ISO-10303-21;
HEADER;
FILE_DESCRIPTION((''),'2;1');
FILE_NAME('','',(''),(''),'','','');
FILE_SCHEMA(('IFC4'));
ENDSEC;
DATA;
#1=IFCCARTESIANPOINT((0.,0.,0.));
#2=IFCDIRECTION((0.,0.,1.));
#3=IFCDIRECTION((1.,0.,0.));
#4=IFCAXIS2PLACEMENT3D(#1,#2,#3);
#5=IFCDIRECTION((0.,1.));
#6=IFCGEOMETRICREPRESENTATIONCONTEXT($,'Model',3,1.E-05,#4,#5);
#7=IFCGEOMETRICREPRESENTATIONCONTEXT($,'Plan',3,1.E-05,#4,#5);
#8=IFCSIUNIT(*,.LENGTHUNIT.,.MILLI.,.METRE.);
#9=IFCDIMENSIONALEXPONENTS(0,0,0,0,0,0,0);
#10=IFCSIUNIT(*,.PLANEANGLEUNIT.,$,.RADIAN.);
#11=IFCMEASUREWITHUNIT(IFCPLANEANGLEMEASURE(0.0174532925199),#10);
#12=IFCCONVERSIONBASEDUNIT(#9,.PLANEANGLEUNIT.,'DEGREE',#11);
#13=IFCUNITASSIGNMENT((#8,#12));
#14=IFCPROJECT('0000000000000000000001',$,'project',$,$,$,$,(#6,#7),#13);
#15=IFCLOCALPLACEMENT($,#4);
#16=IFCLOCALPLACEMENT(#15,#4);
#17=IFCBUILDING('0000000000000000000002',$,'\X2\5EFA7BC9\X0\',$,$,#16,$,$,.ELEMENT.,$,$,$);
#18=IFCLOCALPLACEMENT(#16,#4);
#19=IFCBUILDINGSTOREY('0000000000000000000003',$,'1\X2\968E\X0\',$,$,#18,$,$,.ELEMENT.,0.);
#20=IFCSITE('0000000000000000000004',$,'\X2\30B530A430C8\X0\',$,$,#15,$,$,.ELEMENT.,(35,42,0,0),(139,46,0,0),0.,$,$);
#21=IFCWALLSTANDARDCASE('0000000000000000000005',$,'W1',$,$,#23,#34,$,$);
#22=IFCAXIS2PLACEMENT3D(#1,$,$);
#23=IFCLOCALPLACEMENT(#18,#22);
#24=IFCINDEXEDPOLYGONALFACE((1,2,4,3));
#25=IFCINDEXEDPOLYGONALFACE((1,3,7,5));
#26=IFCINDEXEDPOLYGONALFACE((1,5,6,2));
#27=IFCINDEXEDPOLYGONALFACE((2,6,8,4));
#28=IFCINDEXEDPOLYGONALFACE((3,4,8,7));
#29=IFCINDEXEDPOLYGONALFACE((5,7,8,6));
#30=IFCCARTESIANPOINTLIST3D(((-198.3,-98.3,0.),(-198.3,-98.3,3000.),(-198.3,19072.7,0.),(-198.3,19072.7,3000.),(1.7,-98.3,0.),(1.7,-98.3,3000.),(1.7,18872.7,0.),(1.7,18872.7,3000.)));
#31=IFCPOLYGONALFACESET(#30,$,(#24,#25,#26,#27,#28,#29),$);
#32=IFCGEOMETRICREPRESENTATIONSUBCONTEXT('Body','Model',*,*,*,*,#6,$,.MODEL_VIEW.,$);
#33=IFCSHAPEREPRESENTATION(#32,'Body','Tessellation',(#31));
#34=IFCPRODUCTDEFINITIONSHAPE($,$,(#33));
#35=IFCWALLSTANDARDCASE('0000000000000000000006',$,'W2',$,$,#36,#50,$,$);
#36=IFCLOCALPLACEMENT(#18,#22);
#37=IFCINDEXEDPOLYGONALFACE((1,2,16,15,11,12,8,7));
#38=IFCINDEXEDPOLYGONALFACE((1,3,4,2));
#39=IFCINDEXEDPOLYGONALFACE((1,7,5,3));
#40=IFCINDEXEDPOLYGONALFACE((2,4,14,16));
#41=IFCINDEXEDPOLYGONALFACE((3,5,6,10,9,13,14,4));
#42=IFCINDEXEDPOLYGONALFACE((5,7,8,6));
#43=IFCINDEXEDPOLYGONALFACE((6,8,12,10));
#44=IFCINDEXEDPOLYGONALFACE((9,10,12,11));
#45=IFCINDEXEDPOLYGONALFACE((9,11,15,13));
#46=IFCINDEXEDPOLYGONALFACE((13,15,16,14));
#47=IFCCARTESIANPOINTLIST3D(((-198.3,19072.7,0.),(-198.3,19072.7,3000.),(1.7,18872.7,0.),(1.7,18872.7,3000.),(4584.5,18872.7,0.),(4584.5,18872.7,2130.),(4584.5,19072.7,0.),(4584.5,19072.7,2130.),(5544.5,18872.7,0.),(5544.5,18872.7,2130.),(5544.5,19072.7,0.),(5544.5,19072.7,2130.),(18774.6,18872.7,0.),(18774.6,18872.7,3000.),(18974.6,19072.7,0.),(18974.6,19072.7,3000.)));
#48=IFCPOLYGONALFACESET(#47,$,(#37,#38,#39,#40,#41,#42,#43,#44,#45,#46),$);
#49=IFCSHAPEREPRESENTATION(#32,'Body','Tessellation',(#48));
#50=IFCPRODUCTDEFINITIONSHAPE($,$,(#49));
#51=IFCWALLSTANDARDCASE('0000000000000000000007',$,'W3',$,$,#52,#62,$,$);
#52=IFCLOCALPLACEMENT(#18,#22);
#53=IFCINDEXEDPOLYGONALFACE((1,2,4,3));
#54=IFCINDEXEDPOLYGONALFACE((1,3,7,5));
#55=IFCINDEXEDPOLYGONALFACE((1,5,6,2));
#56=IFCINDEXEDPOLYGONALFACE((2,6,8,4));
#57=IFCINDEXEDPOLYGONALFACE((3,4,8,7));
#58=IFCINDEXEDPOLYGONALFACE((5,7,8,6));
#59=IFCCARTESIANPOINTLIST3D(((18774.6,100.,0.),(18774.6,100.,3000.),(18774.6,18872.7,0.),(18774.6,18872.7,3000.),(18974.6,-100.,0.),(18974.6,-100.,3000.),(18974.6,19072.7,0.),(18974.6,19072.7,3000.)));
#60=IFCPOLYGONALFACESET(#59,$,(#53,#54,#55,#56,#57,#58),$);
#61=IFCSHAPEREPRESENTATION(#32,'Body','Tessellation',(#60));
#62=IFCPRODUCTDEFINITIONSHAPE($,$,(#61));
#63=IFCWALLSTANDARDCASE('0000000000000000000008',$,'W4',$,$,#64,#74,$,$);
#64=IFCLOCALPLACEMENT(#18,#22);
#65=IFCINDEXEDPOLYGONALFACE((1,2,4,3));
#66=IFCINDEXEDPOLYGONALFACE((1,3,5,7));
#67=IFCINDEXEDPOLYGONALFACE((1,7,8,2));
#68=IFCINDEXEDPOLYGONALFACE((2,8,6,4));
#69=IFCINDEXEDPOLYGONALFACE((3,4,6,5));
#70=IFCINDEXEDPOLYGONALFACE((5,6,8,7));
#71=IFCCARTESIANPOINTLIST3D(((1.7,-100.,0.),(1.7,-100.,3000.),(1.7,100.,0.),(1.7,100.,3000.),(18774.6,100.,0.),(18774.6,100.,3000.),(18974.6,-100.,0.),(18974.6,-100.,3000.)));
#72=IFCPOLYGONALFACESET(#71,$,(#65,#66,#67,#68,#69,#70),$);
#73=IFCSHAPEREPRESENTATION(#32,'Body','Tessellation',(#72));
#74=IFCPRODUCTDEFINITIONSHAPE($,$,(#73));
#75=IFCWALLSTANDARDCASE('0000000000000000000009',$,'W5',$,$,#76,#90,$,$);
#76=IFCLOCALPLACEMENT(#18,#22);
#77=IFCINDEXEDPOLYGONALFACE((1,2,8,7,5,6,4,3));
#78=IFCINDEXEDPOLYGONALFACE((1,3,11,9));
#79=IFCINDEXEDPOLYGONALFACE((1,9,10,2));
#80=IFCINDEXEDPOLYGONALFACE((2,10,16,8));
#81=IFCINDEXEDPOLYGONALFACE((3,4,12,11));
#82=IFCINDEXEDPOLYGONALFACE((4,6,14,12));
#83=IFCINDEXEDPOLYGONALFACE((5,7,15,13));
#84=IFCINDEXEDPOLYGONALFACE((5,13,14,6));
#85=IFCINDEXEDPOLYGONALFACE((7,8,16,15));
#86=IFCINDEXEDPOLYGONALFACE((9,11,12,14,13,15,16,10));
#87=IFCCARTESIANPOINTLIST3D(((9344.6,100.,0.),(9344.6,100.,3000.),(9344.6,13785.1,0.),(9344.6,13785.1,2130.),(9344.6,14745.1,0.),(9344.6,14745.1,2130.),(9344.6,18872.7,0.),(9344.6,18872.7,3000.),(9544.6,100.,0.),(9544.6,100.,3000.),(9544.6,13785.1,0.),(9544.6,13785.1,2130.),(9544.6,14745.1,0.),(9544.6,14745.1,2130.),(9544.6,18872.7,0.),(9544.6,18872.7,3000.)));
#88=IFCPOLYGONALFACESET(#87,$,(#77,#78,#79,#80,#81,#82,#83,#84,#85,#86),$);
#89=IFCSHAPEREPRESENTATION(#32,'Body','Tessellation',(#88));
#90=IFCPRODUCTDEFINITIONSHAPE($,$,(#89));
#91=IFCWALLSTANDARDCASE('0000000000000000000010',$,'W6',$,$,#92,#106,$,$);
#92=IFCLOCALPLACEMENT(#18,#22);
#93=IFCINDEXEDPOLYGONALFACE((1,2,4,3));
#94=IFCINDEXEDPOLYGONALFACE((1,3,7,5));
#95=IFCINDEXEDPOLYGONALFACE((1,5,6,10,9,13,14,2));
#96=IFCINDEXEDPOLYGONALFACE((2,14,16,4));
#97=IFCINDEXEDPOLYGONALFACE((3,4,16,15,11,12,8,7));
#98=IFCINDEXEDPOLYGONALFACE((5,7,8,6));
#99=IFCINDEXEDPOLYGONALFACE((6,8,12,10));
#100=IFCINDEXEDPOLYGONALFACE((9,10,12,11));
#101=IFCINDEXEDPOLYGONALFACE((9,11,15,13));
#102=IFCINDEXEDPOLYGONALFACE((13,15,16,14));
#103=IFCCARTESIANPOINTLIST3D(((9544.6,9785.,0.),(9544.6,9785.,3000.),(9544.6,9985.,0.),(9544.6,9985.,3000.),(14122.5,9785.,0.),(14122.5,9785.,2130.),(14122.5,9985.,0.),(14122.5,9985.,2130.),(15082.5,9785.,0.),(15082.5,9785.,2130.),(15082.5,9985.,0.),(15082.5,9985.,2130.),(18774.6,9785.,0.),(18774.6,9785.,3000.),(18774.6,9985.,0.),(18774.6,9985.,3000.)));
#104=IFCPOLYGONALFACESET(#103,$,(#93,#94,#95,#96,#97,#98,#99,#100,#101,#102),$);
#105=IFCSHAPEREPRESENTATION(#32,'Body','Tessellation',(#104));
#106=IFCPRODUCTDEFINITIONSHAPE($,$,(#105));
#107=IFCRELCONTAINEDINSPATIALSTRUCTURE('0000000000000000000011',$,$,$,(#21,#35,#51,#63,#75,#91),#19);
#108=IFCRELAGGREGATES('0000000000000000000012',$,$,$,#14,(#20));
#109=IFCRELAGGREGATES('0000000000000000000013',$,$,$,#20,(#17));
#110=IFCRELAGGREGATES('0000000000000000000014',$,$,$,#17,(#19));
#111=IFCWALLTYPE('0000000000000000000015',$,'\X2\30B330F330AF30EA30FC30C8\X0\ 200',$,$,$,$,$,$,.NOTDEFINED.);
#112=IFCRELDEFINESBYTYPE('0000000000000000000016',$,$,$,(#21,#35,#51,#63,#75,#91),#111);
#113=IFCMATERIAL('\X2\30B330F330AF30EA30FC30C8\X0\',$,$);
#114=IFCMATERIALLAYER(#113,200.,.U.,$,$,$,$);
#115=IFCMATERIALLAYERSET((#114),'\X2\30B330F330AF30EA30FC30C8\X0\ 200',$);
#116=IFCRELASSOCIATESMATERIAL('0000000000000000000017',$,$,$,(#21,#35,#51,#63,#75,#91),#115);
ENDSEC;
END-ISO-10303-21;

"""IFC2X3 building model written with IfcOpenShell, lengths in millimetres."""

from ifc_helpers import new_model, entity, si_unit, converted_unit, direction, frame, origin_with_axes, origin_2d_with_axis, place, context, subcontext, project, spatial, polyline, rectangle, outline, extrude, material, layer, layer_set, layer_usage, type_object, element, save


model = new_model("IFC2X3")

# Units and contexts
model_context = context("Model", 3, precision=1e-05, world=origin_with_axes(), true_north=direction((0.0, 1.0)))
plan_context = context("Plan", 3, precision=1e-05, world=origin_with_axes(), true_north=direction((0.0, 1.0)))
body_context = subcontext(model_context, "Body", "Model", "MODEL_VIEW")
ifc_project = project(units=[si_unit("LENGTHUNIT", "METRE", prefix="MILLI"), converted_unit("PLANEANGLEUNIT", "DEGREE", entity("IfcPlaneAngleMeasure", 0.0174532925199), si_unit("PLANEANGLEUNIT", "RADIAN"), dimensions=[0, 0, 0, 0, 0, 0, 0])], contexts=[model_context, plan_context])

# Site, building, storey
site_placement = place(None, origin_with_axes())
site = spatial("IfcSite", under=ifc_project, at=site_placement, Name="サイト", CompositionType="ELEMENT", RefLatitude=(35, 42, 0, 0), RefLongitude=(139, 46, 0, 0), RefElevation=0.0)
building_placement = place(site_placement, origin_with_axes())
building = spatial("IfcBuilding", under=site, at=building_placement, Name="建築", CompositionType="ELEMENT")
storey_placement = place(building_placement, origin_with_axes())
storey = spatial("IfcBuildingStorey", under=building, at=storey_placement, Name="1階", CompositionType="ELEMENT", Elevation=0.0)

# Wall
ifc_material = material(Name="コンクリート")
ifc_layer = layer(ifc_material, 200.0, ventilated="UNKNOWN")
ifc_layer_set = layer_set([ifc_layer], Name="コンクリート 200")
ifc_layer_usage_1 = layer_usage(ifc_layer_set, "AXIS2", "POSITIVE", -100.0)
wall_type = type_object("IfcWallType", Name="コンクリート 200", PredefinedType="NOTDEFINED")
wall_1_placement = place(storey_placement, frame((-98.3, -98.3, 0.0), z_axis=(0.0, 0.0, 1.0), x_axis=(0.0, 1.0, 0.0)))
element("IfcWallStandardCase", 1, at=wall_1_placement, inside=storey, type_object=wall_type, material=ifc_layer_usage_1, Name="W1", context=body_context, shape_type="SweptSolid", body=[
    extrude(outline(polyline([(0.0, -100.0), (18971.1, -100.0), (19171.1, 100.0), (0.0, 100.0), (0.0, -100.0)])), origin_with_axes(), (0.0, 0.0, 1.0), 3000.0),
])

# Wall, opening
ifc_layer_usage_2 = layer_usage(ifc_layer_set, "AXIS2", "POSITIVE", -100.0)
wall_2_placement = place(storey_placement, frame((-98.3, 18972.7, 0.0), z_axis=(0.0, 0.0, 1.0), x_axis=(1.0, 0.0, 0.0)))
wall_2 = element("IfcWallStandardCase", 2, at=wall_2_placement, inside=storey, type_object=wall_type, material=ifc_layer_usage_2, Name="W2", context=body_context, shape_type="SweptSolid", body=[
    extrude(outline(polyline([(100.0, -100.0), (18873.0, -100.0), (19073.0, 100.0), (-100.0, 100.0), (100.0, -100.0)])), origin_with_axes(), (0.0, 0.0, 1.0), 3000.0),
])
opening_1_placement = place(wall_2_placement, frame((5162.9, 0.0, 0.0), z_axis=(0.0, 0.0, 1.0), x_axis=(1.0, 0.0, 0.0)))
element("IfcOpeningElement", 3, at=opening_1_placement, cuts=wall_2, context=body_context, shape_type="SweptSolid", body=[
    extrude(rectangle(XDim=960.0, YDim=2130.0, at=origin_2d_with_axis()), frame((0.0, 200.0, 1065.0), z_axis=(0.0, 1.0, 0.0), x_axis=(1.0, 0.0, 0.0)), (0.0, 0.0, -1.0), 400.0),
])

# Walls
ifc_layer_usage_3 = layer_usage(ifc_layer_set, "AXIS2", "POSITIVE", -100.0)
wall_3_placement = place(storey_placement, frame((18874.6, 18972.7, 0.0), z_axis=(0.0, 0.0, 1.0), x_axis=(0.0, -1.0, 0.0)))
element("IfcWallStandardCase", 4, at=wall_3_placement, inside=storey, type_object=wall_type, material=ifc_layer_usage_3, Name="W3", context=body_context, shape_type="SweptSolid", body=[
    extrude(outline(polyline([(100.0, -100.0), (18872.7, -100.0), (19072.7, 100.0), (-100.0, 100.0), (100.0, -100.0)])), origin_with_axes(), (0.0, 0.0, 1.0), 3000.0),
])
ifc_layer_usage_4 = layer_usage(ifc_layer_set, "AXIS2", "POSITIVE", -100.0)
wall_4_placement = place(storey_placement, frame((18874.6, 0.0, 0.0), z_axis=(0.0, 0.0, 1.0), x_axis=(-1.0, 0.0, 0.0)))
element("IfcWallStandardCase", 5, at=wall_4_placement, inside=storey, type_object=wall_type, material=ifc_layer_usage_4, Name="W4", context=body_context, shape_type="SweptSolid", body=[
    extrude(outline(polyline([(100.0, -100.0), (18873.0, -100.0), (18873.0, 100.0), (-100.0, 100.0), (100.0, -100.0)])), origin_with_axes(), (0.0, 0.0, 1.0), 3000.0),
])

# Walls, openings
ifc_layer_usage_5 = layer_usage(ifc_layer_set, "AXIS2", "POSITIVE", -100.0)
wall_5_placement = place(storey_placement, frame((9444.6, 18972.7, 0.0), z_axis=(0.0, 0.0, 1.0), x_axis=(0.0, -1.0, 0.0)))
wall_5 = element("IfcWallStandardCase", 6, at=wall_5_placement, inside=storey, type_object=wall_type, material=ifc_layer_usage_5, Name="W5", context=body_context, shape_type="SweptSolid", body=[
    extrude(outline(polyline([(100.0, -100.0), (18872.7, -100.0), (18872.7, 100.0), (100.0, 100.0), (100.0, -100.0)])), origin_with_axes(), (0.0, 0.0, 1.0), 3000.0),
])
opening_2_placement = place(wall_5_placement, frame((4707.6, 0.0, 0.0), z_axis=(0.0, 0.0, 1.0), x_axis=(1.0, 0.0, 0.0)))
element("IfcOpeningElement", 7, at=opening_2_placement, cuts=wall_5, context=body_context, shape_type="SweptSolid", body=[
    extrude(rectangle(XDim=960.0, YDim=2130.0, at=origin_2d_with_axis()), frame((0.0, -200.0, 1065.0), z_axis=(0.0, 1.0, 0.0), x_axis=(1.0, 0.0, 0.0)), (0.0, 0.0, 1.0), 400.0),
])
ifc_layer_usage_6 = layer_usage(ifc_layer_set, "AXIS2", "POSITIVE", -100.0)
wall_6_placement = place(storey_placement, frame((9444.6, 9885.0, 0.0), z_axis=(0.0, 0.0, 1.0), x_axis=(1.0, 0.0, 0.0)))
wall_6 = element("IfcWallStandardCase", 8, at=wall_6_placement, inside=storey, type_object=wall_type, material=ifc_layer_usage_6, Name="W6", context=body_context, shape_type="SweptSolid", body=[
    extrude(outline(polyline([(100.0, -100.0), (9330.0, -100.0), (9330.0, 100.0), (100.0, 100.0), (100.0, -100.0)])), origin_with_axes(), (0.0, 0.0, 1.0), 3000.0),
])
opening_3_placement = place(wall_6_placement, frame((5157.9, 0.0, 0.0), z_axis=(0.0, 0.0, 1.0), x_axis=(1.0, 0.0, 0.0)))
element("IfcOpeningElement", 9, at=opening_3_placement, cuts=wall_6, context=body_context, shape_type="SweptSolid", body=[
    extrude(rectangle(XDim=960.0, YDim=2130.0, at=origin_2d_with_axis()), frame((0.0, 200.0, 1065.0), z_axis=(0.0, -1.0, 0.0), x_axis=(-1.0, 0.0, 0.0)), (0.0, 0.0, 1.0), 400.0),
])

save(model, "model.ifc")
